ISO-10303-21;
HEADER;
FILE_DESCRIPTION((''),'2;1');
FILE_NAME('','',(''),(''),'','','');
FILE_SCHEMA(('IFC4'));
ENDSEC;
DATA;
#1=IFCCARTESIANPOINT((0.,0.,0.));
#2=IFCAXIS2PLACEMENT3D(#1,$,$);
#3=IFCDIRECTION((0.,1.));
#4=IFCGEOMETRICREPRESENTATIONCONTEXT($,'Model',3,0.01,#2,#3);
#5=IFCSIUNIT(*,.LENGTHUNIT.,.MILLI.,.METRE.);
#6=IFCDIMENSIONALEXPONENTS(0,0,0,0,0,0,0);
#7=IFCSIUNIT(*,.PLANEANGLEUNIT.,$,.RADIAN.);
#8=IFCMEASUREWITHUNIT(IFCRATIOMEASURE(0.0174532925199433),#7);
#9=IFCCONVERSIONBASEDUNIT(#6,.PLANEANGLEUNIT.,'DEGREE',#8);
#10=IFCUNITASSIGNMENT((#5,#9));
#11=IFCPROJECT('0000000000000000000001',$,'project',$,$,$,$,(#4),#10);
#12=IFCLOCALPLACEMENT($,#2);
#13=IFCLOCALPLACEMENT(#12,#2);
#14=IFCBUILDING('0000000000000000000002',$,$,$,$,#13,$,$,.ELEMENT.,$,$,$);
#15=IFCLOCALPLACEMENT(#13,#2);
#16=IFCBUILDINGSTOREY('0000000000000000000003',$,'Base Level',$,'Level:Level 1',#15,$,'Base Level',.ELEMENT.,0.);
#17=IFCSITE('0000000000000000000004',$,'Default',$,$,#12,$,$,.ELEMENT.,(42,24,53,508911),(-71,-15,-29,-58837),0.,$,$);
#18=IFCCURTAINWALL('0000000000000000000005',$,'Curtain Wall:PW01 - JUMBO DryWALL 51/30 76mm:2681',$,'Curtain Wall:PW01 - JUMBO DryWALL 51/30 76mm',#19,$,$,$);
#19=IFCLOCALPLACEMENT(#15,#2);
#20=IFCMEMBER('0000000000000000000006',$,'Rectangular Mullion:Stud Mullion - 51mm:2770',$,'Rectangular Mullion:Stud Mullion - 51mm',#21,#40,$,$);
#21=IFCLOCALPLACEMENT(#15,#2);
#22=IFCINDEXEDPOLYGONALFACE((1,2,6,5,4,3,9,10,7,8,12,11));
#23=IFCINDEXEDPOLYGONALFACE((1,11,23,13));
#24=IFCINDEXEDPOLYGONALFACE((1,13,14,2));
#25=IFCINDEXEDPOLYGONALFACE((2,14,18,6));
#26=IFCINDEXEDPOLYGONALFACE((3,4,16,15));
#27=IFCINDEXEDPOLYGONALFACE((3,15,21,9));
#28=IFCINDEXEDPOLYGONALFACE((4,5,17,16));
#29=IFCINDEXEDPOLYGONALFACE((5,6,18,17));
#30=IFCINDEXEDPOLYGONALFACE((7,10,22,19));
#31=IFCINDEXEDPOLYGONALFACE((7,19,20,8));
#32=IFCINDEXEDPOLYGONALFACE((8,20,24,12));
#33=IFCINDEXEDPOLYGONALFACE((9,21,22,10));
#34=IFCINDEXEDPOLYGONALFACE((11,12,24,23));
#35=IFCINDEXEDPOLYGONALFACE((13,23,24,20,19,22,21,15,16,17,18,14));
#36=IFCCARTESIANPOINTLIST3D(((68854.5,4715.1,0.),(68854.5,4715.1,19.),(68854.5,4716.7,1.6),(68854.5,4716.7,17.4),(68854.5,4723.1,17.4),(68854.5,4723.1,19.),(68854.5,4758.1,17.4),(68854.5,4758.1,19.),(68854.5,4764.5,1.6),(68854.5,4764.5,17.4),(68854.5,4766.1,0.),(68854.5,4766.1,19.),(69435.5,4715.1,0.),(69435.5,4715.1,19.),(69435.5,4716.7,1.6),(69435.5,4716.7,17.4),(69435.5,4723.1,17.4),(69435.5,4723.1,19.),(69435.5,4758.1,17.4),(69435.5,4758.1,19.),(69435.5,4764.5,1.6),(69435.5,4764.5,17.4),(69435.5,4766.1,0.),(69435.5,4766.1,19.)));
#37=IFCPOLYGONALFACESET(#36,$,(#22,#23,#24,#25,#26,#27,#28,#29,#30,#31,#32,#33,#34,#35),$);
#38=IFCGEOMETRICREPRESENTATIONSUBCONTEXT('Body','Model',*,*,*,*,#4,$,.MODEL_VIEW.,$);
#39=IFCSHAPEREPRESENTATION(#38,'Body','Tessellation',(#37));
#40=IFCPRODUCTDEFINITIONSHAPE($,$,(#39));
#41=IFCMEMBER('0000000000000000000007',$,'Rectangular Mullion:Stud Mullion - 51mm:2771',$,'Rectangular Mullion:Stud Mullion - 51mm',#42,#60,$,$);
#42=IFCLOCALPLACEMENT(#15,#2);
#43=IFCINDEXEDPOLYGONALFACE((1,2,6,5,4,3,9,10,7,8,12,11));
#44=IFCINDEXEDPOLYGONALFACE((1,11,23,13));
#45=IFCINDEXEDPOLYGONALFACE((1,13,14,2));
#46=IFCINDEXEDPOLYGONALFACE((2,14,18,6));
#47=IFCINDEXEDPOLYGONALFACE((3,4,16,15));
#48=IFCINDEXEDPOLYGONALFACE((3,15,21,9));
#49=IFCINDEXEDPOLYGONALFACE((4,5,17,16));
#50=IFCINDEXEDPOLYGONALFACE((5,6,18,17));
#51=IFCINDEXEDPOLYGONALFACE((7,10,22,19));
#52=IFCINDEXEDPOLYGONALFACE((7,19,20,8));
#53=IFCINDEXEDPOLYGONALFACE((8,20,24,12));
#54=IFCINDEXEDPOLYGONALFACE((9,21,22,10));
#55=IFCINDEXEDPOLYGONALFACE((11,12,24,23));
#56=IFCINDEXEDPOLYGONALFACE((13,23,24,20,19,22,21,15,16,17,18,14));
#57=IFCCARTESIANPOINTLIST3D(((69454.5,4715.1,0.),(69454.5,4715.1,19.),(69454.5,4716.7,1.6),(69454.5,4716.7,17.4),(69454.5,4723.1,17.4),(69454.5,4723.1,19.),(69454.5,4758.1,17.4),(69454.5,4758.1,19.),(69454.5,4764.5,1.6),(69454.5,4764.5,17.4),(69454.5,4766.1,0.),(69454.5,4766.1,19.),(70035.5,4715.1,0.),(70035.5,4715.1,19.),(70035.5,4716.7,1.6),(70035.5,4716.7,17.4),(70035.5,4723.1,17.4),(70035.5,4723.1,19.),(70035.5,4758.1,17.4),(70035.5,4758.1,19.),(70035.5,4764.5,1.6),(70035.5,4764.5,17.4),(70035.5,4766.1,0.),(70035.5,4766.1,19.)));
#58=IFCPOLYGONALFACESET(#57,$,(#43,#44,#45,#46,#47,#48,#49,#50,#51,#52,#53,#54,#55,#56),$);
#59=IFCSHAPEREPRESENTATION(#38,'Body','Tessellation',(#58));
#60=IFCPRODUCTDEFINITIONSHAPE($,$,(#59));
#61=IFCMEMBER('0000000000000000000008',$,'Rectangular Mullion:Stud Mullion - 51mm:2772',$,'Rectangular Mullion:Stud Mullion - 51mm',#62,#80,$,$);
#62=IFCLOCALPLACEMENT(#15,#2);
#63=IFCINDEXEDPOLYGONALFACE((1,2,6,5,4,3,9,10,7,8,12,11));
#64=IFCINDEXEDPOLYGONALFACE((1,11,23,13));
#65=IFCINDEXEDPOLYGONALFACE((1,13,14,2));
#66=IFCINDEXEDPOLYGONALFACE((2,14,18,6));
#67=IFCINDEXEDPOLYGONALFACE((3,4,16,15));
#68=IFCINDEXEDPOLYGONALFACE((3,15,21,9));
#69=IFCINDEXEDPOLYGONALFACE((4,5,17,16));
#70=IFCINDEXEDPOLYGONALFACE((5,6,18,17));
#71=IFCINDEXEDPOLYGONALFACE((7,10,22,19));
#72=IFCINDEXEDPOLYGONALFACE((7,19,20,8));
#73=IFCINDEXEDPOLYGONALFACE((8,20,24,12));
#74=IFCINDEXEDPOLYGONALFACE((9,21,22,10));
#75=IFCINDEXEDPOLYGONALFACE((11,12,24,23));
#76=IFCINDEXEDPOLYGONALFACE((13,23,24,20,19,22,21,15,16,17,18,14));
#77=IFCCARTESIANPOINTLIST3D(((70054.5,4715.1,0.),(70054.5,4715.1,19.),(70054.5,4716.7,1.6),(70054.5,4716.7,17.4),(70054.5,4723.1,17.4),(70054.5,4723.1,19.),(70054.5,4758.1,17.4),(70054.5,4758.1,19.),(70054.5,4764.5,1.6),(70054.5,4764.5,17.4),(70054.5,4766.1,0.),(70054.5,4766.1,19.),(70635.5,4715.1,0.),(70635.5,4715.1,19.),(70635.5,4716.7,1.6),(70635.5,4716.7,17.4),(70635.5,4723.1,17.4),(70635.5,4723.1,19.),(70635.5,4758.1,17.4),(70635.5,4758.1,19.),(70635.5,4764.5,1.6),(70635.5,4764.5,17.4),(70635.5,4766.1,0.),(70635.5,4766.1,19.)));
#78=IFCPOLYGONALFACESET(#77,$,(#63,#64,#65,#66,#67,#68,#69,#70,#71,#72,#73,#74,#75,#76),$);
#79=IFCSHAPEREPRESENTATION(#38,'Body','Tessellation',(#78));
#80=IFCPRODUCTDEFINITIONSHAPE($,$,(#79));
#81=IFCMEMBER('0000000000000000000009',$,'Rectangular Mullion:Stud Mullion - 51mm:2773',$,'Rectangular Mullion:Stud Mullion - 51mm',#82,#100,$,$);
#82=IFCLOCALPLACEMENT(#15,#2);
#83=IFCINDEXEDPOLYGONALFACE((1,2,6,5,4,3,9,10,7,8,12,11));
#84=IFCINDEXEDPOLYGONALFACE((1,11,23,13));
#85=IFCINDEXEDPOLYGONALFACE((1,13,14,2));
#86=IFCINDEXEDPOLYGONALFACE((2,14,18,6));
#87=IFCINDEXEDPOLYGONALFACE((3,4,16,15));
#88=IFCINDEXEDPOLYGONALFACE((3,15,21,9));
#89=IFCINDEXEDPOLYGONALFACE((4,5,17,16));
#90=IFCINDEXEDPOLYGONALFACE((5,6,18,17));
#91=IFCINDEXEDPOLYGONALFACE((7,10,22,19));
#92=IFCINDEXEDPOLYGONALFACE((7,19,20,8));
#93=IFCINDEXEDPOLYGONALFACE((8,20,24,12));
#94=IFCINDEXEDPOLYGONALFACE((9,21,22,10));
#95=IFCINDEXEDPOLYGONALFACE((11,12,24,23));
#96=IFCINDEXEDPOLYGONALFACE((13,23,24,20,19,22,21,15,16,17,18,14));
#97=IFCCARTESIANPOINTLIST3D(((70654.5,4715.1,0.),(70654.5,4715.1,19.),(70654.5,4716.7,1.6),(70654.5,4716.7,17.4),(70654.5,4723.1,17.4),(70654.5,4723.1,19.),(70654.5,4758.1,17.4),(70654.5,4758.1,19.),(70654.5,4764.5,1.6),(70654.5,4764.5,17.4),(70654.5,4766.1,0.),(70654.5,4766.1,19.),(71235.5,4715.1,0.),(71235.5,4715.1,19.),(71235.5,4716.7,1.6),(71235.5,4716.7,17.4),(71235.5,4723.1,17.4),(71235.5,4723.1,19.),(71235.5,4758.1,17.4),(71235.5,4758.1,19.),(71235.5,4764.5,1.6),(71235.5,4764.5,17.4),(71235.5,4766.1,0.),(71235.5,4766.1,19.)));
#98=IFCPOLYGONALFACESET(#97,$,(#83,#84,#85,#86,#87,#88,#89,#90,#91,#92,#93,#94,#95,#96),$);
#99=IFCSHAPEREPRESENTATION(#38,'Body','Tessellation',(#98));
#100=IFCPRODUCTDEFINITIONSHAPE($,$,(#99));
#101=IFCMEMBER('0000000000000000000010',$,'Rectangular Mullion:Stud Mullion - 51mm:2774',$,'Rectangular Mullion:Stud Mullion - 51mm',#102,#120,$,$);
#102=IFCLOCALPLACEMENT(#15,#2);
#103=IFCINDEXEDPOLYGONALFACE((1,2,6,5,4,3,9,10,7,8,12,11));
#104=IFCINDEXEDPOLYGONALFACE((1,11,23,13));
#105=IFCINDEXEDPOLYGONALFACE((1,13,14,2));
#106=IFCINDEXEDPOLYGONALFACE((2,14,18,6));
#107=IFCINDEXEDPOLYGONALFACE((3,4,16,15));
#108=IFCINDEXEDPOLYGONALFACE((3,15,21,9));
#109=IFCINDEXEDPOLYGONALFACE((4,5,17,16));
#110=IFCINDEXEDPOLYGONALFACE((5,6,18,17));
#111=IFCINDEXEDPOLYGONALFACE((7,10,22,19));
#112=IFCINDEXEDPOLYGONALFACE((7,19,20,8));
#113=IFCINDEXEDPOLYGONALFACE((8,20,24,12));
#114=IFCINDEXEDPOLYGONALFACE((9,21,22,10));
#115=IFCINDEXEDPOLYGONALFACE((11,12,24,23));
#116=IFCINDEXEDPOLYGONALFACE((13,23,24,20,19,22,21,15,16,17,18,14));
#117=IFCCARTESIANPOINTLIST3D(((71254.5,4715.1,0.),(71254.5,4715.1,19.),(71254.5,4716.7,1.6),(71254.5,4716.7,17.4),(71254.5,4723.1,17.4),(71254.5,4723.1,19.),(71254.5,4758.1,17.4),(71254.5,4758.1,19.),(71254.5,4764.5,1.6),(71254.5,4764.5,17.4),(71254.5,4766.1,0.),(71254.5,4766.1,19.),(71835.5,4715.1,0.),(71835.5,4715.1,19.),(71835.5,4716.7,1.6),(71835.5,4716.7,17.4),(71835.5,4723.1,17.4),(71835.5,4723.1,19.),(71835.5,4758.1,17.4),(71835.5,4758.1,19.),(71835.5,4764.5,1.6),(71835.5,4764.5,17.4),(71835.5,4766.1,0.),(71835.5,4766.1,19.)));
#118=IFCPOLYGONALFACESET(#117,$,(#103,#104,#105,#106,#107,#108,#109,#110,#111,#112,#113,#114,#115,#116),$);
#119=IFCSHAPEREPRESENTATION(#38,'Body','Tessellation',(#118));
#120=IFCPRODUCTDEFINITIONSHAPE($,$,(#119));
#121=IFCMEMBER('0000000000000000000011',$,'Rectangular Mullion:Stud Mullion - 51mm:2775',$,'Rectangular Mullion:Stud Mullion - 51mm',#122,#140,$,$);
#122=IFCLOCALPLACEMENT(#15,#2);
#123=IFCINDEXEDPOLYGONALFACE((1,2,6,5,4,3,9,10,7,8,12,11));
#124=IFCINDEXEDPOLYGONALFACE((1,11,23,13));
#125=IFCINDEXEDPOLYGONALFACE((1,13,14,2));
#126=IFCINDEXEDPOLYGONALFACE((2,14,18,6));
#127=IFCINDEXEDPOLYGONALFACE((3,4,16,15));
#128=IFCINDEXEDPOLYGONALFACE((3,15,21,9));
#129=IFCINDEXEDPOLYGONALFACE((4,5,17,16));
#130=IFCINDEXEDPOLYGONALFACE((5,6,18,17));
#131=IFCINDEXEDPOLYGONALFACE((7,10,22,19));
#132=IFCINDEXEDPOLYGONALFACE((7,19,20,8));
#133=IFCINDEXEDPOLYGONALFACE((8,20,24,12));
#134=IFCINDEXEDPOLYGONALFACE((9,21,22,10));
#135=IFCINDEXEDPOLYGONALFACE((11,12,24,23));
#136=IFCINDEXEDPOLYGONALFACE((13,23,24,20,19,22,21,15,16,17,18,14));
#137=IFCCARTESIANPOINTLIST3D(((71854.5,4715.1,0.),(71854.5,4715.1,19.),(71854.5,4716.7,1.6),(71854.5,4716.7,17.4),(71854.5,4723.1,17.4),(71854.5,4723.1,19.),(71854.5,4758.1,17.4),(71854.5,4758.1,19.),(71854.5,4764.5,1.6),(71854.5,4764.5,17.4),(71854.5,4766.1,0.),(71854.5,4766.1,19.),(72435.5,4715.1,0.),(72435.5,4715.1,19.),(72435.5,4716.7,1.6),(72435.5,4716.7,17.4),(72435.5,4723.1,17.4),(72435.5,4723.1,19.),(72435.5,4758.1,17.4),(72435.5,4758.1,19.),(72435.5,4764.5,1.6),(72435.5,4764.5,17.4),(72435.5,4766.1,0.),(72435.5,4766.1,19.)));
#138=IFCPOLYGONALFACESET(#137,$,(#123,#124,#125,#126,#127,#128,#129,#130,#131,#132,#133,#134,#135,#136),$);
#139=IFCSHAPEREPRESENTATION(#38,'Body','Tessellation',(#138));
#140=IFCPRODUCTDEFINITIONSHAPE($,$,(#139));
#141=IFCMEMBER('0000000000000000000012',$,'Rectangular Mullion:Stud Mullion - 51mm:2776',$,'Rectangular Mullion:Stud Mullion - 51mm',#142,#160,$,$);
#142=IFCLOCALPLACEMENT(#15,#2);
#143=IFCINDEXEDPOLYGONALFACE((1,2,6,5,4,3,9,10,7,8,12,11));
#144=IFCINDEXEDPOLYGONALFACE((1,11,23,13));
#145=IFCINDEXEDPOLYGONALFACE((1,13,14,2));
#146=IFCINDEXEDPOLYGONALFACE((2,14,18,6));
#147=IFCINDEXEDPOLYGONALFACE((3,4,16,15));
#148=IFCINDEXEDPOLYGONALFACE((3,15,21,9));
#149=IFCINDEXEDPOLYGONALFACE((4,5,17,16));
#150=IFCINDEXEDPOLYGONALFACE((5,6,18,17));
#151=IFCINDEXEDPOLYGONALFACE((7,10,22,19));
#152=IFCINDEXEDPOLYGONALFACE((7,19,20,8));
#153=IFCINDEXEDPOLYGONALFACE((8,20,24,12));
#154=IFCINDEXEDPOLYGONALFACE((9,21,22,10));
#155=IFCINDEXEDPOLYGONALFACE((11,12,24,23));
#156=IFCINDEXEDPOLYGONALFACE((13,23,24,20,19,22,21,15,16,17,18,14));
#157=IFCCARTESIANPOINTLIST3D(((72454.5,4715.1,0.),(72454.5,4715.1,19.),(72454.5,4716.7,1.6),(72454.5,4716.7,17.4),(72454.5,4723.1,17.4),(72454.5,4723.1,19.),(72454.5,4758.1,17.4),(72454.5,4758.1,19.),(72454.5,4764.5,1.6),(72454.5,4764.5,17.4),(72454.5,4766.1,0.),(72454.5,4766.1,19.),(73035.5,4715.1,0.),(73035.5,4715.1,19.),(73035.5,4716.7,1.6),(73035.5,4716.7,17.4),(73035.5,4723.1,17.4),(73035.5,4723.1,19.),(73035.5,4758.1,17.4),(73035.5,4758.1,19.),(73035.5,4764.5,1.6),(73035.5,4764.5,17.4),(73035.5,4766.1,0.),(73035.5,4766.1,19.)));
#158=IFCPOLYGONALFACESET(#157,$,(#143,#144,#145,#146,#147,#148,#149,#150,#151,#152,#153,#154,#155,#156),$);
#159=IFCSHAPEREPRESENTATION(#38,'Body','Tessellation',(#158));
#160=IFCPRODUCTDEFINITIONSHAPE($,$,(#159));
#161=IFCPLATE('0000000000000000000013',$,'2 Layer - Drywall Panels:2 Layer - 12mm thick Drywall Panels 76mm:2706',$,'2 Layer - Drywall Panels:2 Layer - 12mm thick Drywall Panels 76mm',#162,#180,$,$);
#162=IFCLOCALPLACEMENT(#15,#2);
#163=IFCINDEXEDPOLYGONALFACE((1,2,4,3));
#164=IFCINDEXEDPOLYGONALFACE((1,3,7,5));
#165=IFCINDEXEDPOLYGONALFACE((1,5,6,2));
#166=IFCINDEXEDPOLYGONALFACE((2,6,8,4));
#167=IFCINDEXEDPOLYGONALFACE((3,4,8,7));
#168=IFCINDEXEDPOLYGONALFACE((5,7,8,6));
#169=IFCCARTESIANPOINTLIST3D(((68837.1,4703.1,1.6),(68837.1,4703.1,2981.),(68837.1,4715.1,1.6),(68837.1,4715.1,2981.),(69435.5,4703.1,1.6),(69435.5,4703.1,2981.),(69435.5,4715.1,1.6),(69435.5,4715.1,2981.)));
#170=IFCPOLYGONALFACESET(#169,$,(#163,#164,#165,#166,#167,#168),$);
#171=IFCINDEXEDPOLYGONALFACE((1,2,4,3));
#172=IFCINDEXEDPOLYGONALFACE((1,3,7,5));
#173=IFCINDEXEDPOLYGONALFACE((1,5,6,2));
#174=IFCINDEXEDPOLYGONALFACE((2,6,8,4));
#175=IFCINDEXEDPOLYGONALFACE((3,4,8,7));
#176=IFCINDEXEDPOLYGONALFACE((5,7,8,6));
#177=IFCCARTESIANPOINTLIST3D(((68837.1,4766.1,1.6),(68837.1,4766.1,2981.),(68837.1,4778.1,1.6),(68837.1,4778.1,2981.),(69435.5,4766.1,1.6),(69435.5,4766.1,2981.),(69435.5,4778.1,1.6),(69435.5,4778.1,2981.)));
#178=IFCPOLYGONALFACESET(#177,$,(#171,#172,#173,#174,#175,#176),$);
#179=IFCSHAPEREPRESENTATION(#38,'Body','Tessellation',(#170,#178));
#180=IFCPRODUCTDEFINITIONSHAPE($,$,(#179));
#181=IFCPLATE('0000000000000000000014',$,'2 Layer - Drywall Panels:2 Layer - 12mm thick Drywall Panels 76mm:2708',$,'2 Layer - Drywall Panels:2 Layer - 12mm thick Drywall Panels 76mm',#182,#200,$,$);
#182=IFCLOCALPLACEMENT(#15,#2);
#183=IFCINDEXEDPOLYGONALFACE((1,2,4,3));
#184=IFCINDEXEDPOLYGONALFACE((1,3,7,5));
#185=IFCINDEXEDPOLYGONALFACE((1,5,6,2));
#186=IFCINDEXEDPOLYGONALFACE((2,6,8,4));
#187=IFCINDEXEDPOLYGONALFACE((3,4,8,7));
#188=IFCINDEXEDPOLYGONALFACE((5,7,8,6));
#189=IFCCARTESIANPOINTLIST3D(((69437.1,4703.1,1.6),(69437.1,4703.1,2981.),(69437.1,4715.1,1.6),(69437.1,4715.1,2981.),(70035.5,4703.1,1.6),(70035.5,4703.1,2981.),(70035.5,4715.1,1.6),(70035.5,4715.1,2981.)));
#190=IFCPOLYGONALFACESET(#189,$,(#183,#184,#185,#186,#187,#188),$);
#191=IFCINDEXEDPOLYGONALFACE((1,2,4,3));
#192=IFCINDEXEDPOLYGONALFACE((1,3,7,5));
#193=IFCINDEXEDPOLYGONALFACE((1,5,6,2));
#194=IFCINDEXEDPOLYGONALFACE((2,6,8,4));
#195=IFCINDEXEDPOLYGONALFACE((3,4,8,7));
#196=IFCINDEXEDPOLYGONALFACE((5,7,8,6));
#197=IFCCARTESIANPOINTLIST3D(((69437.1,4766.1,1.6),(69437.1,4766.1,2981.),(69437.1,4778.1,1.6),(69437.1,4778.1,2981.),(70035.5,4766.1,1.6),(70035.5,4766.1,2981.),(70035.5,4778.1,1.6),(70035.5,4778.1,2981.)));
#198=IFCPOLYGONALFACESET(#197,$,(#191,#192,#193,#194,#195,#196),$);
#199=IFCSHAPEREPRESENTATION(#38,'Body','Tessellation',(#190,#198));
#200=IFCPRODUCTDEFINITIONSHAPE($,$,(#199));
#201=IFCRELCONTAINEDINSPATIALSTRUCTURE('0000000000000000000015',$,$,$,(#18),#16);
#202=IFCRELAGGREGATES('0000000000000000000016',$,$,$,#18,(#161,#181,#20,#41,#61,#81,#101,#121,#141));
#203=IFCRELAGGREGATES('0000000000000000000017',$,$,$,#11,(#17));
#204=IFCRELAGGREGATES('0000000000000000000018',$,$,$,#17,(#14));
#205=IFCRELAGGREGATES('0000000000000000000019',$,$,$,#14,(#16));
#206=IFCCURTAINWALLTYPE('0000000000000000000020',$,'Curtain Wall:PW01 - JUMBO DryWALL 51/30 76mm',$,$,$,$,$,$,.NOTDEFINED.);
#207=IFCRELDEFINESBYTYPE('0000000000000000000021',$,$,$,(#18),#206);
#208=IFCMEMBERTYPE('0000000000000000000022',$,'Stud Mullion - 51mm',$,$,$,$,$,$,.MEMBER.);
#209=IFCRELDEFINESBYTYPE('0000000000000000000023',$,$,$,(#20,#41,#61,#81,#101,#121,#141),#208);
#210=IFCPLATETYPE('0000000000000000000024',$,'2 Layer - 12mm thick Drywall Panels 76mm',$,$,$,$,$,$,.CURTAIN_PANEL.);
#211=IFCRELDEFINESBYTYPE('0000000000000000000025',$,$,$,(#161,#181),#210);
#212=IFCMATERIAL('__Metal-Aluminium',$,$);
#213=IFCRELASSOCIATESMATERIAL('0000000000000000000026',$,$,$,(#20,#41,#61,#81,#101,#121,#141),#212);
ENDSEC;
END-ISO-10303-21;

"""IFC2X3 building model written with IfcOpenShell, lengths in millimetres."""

from ifc_helpers import new_model, entity, si_unit, converted_unit, direction, frame, frame_2d, origin, origin_2d_with_axis, place, context, subcontext, project, spatial, polyline, rectangle, outline, extrude, source, transform, mapped, material, type_object, type_shapes, element, aggregate, save


model = new_model("IFC2X3")

# Units and contexts
model_context = context("Model", 3, precision=0.01, world=origin(), true_north=direction((0.0, 1.0)))
body_context = subcontext(model_context, "Body", "Model", "MODEL_VIEW")
ifc_project = project(units=[si_unit("LENGTHUNIT", "METRE", prefix="MILLI"), converted_unit("PLANEANGLEUNIT", "DEGREE", entity("IfcRatioMeasure", 0.0174532925199433), si_unit("PLANEANGLEUNIT", "RADIAN"), dimensions=[0, 0, 0, 0, 0, 0, 0])], contexts=[model_context])

# Site, building, storey
site_placement = place(None, origin())
site = spatial("IfcSite", under=ifc_project, at=site_placement, Name="Default", CompositionType="ELEMENT", RefLatitude=(42, 24, 53, 508911), RefLongitude=(-71, -15, -29, -58837), RefElevation=0.0)
building_placement = place(site_placement, origin())
building = spatial("IfcBuilding", under=site, at=building_placement, CompositionType="ELEMENT")
storey_placement = place(building_placement, origin())
storey = spatial("IfcBuildingStorey", under=building, at=storey_placement, Name="Base Level", ObjectType="Level:Level 1", LongName="Base Level", CompositionType="ELEMENT", Elevation=0.0)

# Curtain wall, members, plates
curtain_wall_type = type_object("IfcCurtainWallType", Name="Curtain Wall:PW01 - JUMBO DryWALL 51/30 76mm", PredefinedType="NOTDEFINED")
curtain_wall_placement = place(building_placement, origin())
curtain_wall = element("IfcCurtainWall", 1, at=curtain_wall_placement, inside=storey, type_object=curtain_wall_type, Name="Curtain Wall:PW01 - JUMBO DryWALL 51/30 76mm:2681", ObjectType="Curtain Wall:PW01 - JUMBO DryWALL 51/30 76mm")
ifc_material = material(Name="__Metal-Aluminium")
member_type_1 = type_object("IfcMemberType", Name="Stud Mullion - 51mm", PredefinedType="MEMBER")
shared_shape_1 = source(origin(), body_context, "Body", "SweptSolid", [
    extrude(outline(polyline([(17.5, -6.6), (25.5, -6.6), (25.5, 12.4), (-25.5, 12.4), (-25.5, -6.6), (-17.5, -6.6), (-17.5, -5.0), (-23.9, -5.0), (-23.9, 10.8), (23.9, 10.8), (23.9, -5.0), (17.5, -5.0), (17.5, -6.6)])), frame((-12.4, 0.0, -581.0), z_axis=(0.0, 0.0, 1.0), x_axis=(0.0, -1.0, 0.0)), (0.0, 0.0, 1.0), 581.0),
])
type_shapes(member_type_1, [shared_shape_1])
member_1_placement = place(building_placement, frame((68854.5, 4740.6, 0.0), z_axis=(-1.0, 0.0, 0.0), x_axis=(0.0, 0.0, -1.0)))
member_1 = element("IfcMember", 2, at=member_1_placement, type_object=member_type_1, material=ifc_material, Name="Rectangular Mullion:Stud Mullion - 51mm:2770", ObjectType="Rectangular Mullion:Stud Mullion - 51mm", context=body_context, shape_type="MappedRepresentation", body=[
    mapped(shared_shape_1, transform((0.0, 0.0, 0.0), scale=1.0)),
])
member_2_placement = place(building_placement, frame((69454.5, 4740.6, 0.0), z_axis=(-1.0, 0.0, 0.0), x_axis=(0.0, 0.0, -1.0)))
member_2 = element("IfcMember", 3, at=member_2_placement, type_object=member_type_1, material=ifc_material, Name="Rectangular Mullion:Stud Mullion - 51mm:2771", ObjectType="Rectangular Mullion:Stud Mullion - 51mm", context=body_context, shape_type="MappedRepresentation", body=[
    mapped(shared_shape_1, transform((0.0, 0.0, 0.0), scale=1.0)),
])
member_3_placement = place(building_placement, frame((70054.5, 4740.6, 0.0), z_axis=(-1.0, 0.0, 0.0), x_axis=(0.0, 0.0, -1.0)))
member_3 = element("IfcMember", 4, at=member_3_placement, type_object=member_type_1, material=ifc_material, Name="Rectangular Mullion:Stud Mullion - 51mm:2772", ObjectType="Rectangular Mullion:Stud Mullion - 51mm", context=body_context, shape_type="MappedRepresentation", body=[
    mapped(shared_shape_1, transform((0.0, 0.0, 0.0), scale=1.0)),
])
member_4_placement = place(building_placement, frame((70654.5, 4740.6, 0.0), z_axis=(-1.0, 0.0, 0.0), x_axis=(0.0, 0.0, -1.0)))
member_4 = element("IfcMember", 5, at=member_4_placement, type_object=member_type_1, material=ifc_material, Name="Rectangular Mullion:Stud Mullion - 51mm:2773", ObjectType="Rectangular Mullion:Stud Mullion - 51mm", context=body_context, shape_type="MappedRepresentation", body=[
    mapped(shared_shape_1, transform((0.0, 0.0, 0.0), scale=1.0)),
])
member_5_placement = place(building_placement, frame((71254.5, 4740.6, 0.0), z_axis=(-1.0, 0.0, 0.0), x_axis=(0.0, 0.0, -1.0)))
member_5 = element("IfcMember", 6, at=member_5_placement, type_object=member_type_1, material=ifc_material, Name="Rectangular Mullion:Stud Mullion - 51mm:2774", ObjectType="Rectangular Mullion:Stud Mullion - 51mm", context=body_context, shape_type="MappedRepresentation", body=[
    mapped(shared_shape_1, transform((0.0, 0.0, 0.0), scale=1.0)),
])
member_6_placement = place(building_placement, frame((71854.5, 4740.6, 0.0), z_axis=(-1.0, 0.0, 0.0), x_axis=(0.0, 0.0, -1.0)))
member_6 = element("IfcMember", 7, at=member_6_placement, type_object=member_type_1, material=ifc_material, Name="Rectangular Mullion:Stud Mullion - 51mm:2775", ObjectType="Rectangular Mullion:Stud Mullion - 51mm", context=body_context, shape_type="MappedRepresentation", body=[
    mapped(shared_shape_1, transform((0.0, 0.0, 0.0), scale=1.0)),
])
member_7_placement = place(building_placement, frame((72454.5, 4740.6, 0.0), z_axis=(-1.0, 0.0, 0.0), x_axis=(0.0, 0.0, -1.0)))
member_7 = element("IfcMember", 8, at=member_7_placement, type_object=member_type_1, material=ifc_material, Name="Rectangular Mullion:Stud Mullion - 51mm:2776", ObjectType="Rectangular Mullion:Stud Mullion - 51mm", context=body_context, shape_type="MappedRepresentation", body=[
    mapped(shared_shape_1, transform((0.0, 0.0, 0.0), scale=1.0)),
])
plate_type = type_object("IfcPlateType", Name="2 Layer - 12mm thick Drywall Panels 76mm", PredefinedType="CURTAIN_PANEL")
shared_shape_2 = source(origin(), body_context, "Body", "SweptSolid", [
    extrude(rectangle(XDim=598.4, YDim=12.0, at=origin_2d_with_axis()), frame((0.0, -31.5, 0.0), z_axis=(0.0, 0.0, 1.0), x_axis=(-1.0, 0.0, 0.0)), (0.0, 0.0, 1.0), 2979.4),
    extrude(rectangle(XDim=12.0, YDim=598.4, at=frame_2d((0.0, 0.0), x_axis=(1.0, 0.0))), frame((0.0, 31.5, 0.0), z_axis=(0.0, 0.0, 1.0), x_axis=(0.0, 1.0, 0.0)), (0.0, 0.0, 1.0), 2979.4),
])
type_shapes(plate_type, [shared_shape_2])
plate_1_placement = place(curtain_wall_placement, frame((69136.3, 4740.6, 1.6)))
plate_1 = element("IfcPlate", 9, at=plate_1_placement, type_object=plate_type, Name="2 Layer - Drywall Panels:2 Layer - 12mm thick Drywall Panels 76mm:2706", ObjectType="2 Layer - Drywall Panels:2 Layer - 12mm thick Drywall Panels 76mm", context=body_context, shape_type="MappedRepresentation", body=[
    mapped(shared_shape_2, transform((0.0, 0.0, 0.0), scale=1.0)),
])
plate_2_placement = place(curtain_wall_placement, frame((69736.3, 4740.6, 1.6)))
plate_2 = element("IfcPlate", 10, at=plate_2_placement, type_object=plate_type, Name="2 Layer - Drywall Panels:2 Layer - 12mm thick Drywall Panels 76mm:2708", ObjectType="2 Layer - Drywall Panels:2 Layer - 12mm thick Drywall Panels 76mm", context=body_context, shape_type="MappedRepresentation", body=[
    mapped(shared_shape_2, transform((0.0, 0.0, 0.0), scale=1.0)),
])
aggregate(curtain_wall, [plate_1, plate_2, member_1, member_2, member_3, member_4, member_5, member_6, member_7])

save(model, "model.ifc")
